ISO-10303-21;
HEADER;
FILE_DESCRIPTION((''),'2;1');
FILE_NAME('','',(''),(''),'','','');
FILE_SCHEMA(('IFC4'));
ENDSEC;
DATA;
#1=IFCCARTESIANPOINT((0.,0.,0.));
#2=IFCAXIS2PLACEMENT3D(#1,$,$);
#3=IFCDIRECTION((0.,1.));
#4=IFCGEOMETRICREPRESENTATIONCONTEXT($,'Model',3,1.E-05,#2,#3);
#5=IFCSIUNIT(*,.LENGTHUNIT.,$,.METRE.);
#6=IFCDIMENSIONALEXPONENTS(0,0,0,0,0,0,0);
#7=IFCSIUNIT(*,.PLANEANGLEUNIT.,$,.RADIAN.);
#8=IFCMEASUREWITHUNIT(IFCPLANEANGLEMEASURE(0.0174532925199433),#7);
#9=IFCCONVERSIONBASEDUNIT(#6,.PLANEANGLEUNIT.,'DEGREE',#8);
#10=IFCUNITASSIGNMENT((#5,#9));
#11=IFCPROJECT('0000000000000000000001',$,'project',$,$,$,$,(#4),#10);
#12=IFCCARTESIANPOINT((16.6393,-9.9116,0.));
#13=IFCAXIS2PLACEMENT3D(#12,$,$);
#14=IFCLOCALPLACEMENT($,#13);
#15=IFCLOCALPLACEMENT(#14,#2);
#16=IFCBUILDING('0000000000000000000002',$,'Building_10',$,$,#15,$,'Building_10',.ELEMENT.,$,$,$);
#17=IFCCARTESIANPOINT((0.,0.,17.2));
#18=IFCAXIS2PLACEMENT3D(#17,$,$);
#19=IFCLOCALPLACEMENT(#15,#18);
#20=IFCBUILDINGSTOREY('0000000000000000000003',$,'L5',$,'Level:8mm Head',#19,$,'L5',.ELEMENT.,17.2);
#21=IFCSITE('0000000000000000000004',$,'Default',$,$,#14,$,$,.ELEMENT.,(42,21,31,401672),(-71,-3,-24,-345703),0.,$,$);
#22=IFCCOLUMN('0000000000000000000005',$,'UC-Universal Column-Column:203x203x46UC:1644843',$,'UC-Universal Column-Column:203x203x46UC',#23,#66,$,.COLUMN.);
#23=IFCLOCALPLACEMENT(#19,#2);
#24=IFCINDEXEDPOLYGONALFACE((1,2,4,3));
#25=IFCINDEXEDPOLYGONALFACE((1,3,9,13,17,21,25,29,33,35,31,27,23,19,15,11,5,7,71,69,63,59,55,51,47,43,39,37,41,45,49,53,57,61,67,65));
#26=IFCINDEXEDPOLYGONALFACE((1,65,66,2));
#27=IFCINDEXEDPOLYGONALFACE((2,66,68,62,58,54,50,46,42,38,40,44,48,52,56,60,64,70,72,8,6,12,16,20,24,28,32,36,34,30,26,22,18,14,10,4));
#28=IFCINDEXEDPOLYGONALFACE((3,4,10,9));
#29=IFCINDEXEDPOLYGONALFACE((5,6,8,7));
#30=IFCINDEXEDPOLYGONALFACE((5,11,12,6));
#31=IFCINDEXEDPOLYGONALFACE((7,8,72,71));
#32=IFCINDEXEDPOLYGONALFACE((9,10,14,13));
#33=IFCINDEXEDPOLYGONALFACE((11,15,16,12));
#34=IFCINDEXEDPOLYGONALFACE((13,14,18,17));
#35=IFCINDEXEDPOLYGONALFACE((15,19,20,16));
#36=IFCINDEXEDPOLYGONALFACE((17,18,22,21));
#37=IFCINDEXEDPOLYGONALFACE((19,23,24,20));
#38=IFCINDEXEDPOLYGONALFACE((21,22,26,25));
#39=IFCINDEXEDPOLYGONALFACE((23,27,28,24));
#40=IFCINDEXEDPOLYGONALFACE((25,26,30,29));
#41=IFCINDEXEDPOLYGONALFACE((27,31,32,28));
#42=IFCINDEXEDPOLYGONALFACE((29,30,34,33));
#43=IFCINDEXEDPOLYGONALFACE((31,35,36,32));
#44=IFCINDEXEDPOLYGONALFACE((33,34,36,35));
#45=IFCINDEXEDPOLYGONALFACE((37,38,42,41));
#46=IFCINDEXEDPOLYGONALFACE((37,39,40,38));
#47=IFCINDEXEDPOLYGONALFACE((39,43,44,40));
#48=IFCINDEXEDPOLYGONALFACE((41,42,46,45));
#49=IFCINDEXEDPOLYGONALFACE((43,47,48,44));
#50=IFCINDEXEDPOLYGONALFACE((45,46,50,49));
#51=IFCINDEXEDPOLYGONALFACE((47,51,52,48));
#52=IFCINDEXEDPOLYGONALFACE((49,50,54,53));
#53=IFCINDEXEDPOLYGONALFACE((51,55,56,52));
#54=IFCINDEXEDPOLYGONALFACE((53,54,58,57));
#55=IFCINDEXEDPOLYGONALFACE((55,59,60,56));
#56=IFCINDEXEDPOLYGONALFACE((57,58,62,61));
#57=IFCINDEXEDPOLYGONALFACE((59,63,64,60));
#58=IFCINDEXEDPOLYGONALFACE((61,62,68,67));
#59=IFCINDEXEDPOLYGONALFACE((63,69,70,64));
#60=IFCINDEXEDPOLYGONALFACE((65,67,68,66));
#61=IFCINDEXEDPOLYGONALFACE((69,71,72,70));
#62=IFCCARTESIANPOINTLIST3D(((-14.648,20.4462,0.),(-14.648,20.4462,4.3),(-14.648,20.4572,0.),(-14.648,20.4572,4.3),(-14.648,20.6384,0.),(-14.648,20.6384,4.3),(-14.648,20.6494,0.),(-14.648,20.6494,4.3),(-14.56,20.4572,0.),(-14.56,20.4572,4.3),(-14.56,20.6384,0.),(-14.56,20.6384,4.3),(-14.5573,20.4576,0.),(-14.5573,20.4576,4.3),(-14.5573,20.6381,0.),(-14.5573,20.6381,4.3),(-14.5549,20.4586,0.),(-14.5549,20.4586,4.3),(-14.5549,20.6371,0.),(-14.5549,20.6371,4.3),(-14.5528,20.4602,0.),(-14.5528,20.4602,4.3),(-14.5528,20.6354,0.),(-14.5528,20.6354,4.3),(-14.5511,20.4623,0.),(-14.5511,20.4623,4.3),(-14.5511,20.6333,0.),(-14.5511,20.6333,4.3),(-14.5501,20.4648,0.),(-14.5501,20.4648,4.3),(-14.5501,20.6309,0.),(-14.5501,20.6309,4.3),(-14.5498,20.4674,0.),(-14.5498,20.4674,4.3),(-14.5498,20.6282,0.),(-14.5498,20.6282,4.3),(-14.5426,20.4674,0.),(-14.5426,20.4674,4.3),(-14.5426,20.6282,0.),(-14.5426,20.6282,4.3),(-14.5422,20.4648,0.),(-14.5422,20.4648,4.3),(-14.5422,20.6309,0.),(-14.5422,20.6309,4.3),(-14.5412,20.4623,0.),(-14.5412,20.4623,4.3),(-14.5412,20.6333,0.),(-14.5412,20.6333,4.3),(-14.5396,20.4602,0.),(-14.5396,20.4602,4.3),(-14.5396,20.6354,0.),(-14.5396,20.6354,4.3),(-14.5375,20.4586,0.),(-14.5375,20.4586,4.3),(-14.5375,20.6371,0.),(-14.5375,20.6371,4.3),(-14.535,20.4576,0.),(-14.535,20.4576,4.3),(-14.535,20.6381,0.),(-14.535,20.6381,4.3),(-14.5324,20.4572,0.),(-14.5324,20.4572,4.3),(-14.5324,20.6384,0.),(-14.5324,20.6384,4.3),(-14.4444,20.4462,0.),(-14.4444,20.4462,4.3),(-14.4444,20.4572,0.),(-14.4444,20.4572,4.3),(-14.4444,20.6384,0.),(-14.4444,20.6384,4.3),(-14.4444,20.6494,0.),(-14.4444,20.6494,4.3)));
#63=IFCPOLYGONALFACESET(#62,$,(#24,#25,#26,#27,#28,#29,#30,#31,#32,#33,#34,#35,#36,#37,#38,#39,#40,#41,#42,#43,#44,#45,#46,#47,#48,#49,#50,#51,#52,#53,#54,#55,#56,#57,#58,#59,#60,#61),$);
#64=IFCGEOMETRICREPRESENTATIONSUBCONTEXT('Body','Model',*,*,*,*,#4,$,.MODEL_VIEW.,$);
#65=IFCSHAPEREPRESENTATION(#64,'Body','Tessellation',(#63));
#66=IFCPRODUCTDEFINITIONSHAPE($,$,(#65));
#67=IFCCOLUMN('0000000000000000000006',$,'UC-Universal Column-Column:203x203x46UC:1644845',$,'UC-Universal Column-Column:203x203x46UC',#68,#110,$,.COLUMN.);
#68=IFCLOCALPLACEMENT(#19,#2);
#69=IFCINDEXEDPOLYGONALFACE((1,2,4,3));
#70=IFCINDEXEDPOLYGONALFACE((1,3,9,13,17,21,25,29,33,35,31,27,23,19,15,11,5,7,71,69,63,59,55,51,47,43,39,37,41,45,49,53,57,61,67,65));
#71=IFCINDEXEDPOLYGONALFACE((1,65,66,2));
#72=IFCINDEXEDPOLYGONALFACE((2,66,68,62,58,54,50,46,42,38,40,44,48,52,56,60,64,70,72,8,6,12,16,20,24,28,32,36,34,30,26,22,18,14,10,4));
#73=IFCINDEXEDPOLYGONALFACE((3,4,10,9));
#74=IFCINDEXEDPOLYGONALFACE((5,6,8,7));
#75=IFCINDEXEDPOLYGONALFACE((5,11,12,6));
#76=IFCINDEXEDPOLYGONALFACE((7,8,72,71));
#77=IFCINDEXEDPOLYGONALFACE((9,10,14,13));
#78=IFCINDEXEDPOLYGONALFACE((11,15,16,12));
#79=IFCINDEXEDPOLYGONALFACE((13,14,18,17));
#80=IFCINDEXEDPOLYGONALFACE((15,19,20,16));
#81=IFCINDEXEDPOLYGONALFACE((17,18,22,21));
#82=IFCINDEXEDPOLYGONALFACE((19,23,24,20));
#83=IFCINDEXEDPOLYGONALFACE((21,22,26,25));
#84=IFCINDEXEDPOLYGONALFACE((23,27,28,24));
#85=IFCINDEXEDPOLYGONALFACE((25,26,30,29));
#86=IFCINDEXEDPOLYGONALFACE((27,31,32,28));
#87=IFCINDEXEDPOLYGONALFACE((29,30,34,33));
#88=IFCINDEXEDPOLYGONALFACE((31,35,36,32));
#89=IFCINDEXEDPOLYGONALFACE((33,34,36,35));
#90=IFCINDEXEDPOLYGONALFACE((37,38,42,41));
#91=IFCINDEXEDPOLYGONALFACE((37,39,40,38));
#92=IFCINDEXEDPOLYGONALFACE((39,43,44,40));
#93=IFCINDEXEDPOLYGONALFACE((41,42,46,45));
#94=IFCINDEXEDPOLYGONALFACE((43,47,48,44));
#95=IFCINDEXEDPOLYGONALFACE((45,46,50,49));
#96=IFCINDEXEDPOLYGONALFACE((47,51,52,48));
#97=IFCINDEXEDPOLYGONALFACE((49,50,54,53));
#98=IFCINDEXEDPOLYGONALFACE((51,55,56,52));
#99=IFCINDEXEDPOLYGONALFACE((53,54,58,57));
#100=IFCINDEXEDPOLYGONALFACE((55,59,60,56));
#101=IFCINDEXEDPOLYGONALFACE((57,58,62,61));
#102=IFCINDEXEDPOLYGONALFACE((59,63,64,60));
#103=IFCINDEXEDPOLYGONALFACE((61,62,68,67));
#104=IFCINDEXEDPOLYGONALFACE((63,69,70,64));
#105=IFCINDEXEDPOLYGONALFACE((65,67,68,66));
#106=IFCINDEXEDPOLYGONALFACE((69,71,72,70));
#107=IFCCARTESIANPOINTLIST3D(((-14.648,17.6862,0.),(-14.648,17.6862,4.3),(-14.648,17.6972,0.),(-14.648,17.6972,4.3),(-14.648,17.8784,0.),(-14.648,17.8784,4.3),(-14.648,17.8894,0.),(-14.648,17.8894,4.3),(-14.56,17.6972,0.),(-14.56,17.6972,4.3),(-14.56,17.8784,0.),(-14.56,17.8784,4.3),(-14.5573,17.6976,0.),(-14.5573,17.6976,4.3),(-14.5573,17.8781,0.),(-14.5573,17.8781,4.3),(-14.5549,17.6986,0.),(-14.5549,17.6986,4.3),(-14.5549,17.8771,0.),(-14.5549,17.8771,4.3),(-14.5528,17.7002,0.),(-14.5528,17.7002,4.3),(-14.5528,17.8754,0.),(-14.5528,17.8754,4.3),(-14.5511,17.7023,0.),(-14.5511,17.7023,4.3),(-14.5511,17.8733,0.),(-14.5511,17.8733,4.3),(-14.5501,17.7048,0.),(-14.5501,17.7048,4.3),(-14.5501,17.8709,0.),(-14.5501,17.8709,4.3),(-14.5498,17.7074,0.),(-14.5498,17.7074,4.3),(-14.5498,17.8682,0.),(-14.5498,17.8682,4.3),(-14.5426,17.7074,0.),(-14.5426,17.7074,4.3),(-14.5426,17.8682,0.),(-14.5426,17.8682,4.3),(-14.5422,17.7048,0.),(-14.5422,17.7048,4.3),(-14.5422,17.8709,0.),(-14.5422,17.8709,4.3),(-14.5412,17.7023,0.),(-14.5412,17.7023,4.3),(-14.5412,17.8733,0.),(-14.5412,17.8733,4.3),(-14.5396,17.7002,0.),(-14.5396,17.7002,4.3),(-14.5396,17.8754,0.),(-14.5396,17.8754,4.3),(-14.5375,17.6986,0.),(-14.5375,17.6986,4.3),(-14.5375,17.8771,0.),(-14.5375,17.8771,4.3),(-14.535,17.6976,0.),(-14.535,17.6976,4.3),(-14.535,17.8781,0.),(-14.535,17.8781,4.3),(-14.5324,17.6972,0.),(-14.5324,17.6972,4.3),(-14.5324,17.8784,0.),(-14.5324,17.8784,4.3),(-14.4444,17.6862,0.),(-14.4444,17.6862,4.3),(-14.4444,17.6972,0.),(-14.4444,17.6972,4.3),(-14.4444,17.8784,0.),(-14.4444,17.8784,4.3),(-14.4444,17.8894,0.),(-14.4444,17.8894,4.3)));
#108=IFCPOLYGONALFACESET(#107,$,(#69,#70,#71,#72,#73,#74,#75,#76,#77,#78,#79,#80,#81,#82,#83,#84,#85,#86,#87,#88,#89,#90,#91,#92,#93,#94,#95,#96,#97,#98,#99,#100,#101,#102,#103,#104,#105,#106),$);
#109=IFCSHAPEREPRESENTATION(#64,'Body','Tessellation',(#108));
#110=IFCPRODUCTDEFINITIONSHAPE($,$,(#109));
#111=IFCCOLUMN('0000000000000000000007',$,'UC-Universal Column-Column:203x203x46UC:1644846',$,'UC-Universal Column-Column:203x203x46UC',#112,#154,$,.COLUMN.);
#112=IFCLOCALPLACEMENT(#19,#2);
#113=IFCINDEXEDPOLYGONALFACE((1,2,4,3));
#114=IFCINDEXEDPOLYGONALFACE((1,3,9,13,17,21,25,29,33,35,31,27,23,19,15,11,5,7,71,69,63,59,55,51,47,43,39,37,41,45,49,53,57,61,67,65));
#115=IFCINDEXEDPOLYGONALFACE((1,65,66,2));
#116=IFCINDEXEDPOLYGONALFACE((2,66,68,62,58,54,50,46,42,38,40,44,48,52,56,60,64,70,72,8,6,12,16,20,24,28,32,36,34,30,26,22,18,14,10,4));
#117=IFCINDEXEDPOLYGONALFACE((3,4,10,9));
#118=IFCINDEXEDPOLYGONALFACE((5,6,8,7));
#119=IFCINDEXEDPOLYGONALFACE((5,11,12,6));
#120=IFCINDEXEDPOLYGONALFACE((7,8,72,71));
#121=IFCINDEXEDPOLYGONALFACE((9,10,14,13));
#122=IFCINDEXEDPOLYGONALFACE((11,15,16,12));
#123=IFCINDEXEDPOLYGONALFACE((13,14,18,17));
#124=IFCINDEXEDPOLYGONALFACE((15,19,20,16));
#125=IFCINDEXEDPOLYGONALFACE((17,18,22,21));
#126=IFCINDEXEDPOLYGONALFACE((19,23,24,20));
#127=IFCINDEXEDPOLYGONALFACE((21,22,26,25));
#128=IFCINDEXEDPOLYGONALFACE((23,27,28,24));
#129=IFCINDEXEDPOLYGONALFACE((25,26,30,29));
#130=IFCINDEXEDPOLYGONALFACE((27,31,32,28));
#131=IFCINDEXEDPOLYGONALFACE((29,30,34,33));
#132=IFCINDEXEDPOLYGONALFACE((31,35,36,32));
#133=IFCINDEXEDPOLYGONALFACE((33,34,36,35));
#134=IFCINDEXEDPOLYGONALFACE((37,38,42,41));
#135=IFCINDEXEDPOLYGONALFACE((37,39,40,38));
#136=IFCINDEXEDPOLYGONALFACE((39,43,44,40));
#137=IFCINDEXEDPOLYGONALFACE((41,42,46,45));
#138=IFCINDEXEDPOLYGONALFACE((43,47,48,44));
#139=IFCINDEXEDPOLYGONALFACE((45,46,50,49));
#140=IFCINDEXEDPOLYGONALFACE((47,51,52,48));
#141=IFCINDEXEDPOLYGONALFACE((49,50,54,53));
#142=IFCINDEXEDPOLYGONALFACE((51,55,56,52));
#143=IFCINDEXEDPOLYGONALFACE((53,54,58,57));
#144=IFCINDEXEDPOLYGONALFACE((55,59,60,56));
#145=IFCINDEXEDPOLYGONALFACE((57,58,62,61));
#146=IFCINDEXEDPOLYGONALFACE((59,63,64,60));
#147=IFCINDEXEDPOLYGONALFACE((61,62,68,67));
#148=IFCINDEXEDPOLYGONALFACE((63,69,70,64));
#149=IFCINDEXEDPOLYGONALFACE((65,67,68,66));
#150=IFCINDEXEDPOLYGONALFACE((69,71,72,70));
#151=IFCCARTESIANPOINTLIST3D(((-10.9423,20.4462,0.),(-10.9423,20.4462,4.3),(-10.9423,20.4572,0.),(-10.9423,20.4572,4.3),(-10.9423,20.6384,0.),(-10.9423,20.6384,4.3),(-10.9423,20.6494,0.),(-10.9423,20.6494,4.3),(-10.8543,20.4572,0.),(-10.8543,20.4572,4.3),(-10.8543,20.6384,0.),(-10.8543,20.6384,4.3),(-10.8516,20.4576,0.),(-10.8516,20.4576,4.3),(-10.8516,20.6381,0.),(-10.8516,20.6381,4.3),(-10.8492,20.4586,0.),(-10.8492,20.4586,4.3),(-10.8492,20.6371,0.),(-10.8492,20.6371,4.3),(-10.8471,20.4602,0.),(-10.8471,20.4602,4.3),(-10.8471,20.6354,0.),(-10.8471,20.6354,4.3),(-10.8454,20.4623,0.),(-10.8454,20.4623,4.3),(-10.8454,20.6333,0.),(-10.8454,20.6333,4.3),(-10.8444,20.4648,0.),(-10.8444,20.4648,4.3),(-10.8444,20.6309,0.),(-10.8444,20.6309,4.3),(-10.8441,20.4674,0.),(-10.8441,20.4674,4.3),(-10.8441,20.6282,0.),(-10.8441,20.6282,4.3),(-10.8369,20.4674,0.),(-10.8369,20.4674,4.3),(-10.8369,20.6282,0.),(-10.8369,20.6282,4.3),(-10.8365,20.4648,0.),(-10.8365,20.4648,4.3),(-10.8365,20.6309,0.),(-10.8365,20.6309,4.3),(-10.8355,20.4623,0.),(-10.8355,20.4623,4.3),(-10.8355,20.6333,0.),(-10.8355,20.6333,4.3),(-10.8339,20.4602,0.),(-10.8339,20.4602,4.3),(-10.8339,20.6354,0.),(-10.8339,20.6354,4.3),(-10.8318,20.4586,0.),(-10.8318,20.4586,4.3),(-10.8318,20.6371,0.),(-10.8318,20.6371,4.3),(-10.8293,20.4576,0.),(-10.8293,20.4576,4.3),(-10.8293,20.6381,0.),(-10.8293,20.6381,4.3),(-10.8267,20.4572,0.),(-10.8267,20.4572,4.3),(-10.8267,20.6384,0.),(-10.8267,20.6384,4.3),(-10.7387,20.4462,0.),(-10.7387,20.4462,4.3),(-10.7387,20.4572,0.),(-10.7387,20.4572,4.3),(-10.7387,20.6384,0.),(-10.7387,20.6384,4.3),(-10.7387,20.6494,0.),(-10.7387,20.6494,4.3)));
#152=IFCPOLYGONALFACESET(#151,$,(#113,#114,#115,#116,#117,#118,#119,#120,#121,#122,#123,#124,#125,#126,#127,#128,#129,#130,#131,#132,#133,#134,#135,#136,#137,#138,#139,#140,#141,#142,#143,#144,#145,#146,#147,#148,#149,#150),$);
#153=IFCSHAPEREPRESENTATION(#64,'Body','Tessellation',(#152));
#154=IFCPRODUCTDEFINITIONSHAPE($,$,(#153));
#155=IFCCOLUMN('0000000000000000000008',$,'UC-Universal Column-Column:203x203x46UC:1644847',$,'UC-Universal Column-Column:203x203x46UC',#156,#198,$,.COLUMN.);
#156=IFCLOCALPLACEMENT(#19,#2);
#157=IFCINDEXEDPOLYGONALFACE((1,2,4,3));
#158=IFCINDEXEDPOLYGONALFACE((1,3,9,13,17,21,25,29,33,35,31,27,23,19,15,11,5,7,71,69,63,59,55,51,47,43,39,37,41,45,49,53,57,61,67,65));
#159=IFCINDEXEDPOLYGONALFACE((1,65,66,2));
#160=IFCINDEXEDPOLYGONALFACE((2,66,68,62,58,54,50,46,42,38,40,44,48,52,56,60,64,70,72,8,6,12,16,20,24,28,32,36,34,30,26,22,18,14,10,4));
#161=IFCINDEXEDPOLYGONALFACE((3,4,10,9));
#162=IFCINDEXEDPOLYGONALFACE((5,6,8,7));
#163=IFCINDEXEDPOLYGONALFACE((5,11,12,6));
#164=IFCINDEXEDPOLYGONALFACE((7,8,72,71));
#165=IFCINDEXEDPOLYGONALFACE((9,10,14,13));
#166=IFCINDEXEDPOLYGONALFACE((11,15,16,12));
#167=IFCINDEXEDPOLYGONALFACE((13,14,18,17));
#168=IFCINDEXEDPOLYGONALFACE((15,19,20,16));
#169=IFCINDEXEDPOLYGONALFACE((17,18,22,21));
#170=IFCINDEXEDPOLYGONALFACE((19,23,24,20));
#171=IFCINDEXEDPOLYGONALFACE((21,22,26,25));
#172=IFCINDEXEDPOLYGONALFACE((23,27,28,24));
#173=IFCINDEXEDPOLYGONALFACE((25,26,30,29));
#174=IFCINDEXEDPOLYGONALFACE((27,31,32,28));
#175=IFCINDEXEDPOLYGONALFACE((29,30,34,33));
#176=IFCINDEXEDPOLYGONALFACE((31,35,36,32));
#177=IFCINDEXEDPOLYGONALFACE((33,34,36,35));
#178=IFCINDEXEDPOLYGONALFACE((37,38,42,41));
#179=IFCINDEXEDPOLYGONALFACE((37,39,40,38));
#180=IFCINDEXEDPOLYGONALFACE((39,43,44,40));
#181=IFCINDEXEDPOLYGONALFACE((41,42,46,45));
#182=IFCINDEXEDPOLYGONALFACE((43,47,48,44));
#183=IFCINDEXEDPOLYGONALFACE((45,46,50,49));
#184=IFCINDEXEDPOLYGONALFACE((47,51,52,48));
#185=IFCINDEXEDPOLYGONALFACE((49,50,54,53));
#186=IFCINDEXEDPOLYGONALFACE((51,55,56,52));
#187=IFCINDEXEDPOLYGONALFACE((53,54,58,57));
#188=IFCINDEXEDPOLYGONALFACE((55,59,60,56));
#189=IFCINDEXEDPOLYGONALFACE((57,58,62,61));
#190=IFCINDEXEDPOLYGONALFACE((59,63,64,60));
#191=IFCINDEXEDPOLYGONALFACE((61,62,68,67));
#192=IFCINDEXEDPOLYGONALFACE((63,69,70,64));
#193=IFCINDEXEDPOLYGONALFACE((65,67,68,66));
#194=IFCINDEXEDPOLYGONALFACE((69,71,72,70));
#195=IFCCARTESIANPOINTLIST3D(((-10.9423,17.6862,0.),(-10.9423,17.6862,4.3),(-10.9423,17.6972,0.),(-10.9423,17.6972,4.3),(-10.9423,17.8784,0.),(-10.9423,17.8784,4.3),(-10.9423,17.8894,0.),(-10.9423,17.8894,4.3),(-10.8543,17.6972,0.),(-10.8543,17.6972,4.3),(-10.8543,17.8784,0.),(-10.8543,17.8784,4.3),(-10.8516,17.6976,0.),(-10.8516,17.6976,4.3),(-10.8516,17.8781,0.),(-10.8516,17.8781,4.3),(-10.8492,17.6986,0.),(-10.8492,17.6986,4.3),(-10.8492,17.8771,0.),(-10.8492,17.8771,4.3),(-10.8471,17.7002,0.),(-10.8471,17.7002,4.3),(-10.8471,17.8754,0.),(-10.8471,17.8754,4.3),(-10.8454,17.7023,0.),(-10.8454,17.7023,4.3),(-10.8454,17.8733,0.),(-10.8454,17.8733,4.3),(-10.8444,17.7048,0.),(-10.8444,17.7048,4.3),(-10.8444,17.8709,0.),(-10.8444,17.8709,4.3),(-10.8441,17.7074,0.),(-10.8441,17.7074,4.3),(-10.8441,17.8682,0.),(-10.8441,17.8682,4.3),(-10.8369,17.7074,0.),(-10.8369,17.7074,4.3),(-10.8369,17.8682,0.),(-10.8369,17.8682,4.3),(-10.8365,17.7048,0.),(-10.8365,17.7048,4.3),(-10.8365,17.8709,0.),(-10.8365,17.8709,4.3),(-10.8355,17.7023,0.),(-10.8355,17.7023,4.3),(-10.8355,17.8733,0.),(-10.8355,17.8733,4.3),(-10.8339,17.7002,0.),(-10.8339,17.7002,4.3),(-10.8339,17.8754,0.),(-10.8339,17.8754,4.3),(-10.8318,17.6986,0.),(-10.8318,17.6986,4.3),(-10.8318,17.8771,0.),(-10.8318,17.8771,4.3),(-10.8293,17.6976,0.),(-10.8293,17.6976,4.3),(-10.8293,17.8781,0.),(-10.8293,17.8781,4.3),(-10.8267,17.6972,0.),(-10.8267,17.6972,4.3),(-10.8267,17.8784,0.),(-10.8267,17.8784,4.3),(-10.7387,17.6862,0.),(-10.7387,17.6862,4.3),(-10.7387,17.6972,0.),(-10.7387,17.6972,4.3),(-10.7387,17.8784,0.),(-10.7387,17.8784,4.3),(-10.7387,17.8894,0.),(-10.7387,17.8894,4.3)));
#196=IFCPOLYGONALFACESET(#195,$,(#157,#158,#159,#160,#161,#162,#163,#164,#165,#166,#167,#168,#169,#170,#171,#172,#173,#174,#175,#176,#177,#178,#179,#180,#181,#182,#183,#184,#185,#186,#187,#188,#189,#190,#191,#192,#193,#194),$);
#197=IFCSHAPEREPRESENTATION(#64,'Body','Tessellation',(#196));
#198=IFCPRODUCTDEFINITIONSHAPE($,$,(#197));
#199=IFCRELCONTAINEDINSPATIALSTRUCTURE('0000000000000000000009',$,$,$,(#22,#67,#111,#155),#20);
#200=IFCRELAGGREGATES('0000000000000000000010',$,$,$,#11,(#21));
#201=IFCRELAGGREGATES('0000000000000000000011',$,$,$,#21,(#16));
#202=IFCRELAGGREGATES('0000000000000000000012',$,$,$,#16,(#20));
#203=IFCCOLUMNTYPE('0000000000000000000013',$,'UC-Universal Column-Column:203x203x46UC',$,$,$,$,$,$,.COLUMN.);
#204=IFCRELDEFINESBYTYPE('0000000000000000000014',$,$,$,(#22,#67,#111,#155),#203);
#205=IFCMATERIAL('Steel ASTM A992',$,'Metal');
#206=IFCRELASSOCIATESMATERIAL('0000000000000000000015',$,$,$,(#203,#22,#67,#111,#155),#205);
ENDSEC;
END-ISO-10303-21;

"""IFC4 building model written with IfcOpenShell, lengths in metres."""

from ifc_helpers import new_model, entity, si_unit, converted_unit, direction, frame, origin, place, context, subcontext, project, spatial, line, arc, indexed_curve, outline, extrude, source, transform, mapped, material, type_object, type_shapes, element, save


model = new_model("IFC4")

# Units and contexts
model_context = context("Model", 3, precision=1e-05, world=origin(), true_north=direction((0.0, 1.0)))
body_context = subcontext(model_context, "Body", "Model", "MODEL_VIEW")
ifc_project = project(units=[si_unit("LENGTHUNIT", "METRE"), converted_unit("PLANEANGLEUNIT", "DEGREE", entity("IfcPlaneAngleMeasure", 0.0174532925199433), si_unit("PLANEANGLEUNIT", "RADIAN"), dimensions=[0, 0, 0, 0, 0, 0, 0])], contexts=[model_context])

# Site, building, storey
site_placement = place(None, frame((16.6393, -9.9116, 0.0)))
site = spatial("IfcSite", under=ifc_project, at=site_placement, Name="Default", CompositionType="ELEMENT", RefLatitude=(42, 21, 31, 401672), RefLongitude=(-71, -3, -24, -345703), RefElevation=0.0)
building_placement = place(site_placement, origin())
building = spatial("IfcBuilding", under=site, at=building_placement, Name="Building_10", LongName="Building_10", CompositionType="ELEMENT")
storey_placement = place(building_placement, frame((0.0, 0.0, 17.2)))
storey = spatial("IfcBuildingStorey", under=building, at=storey_placement, Name="L5", ObjectType="Level:8mm Head", LongName="L5", CompositionType="ELEMENT", Elevation=17.2)

# Columns
ifc_material = material(Name="Steel ASTM A992", Category="Metal")
column_type = type_object("IfcColumnType", Name="UC-Universal Column-Column:203x203x46UC", PredefinedType="COLUMN", material=ifc_material)
shared_shape_1 = source(origin(), body_context, "Body", "SweptSolid", [
    extrude(outline(indexed_curve([(-0.1018, -0.1016), (0.1018, -0.1016), (0.1018, -0.0906), (0.0138, -0.0906), (0.0066, -0.0876), (0.0036, -0.0804), (0.0036, 0.0804), (0.0066, 0.0876), (0.0138, 0.0906), (0.1018, 0.0906), (0.1018, 0.1016), (-0.1018, 0.1016), (-0.1018, 0.0906), (-0.0138, 0.0906), (-0.0066, 0.0876), (-0.0036, 0.0804), (-0.0036, -0.0804), (-0.0066, -0.0876), (-0.0138, -0.0906), (-0.1018, -0.0906)], segments=[line(1, 2, 3, 4), arc(4, 5, 6), line(6, 7), arc(7, 8, 9), line(9, 10, 11, 12, 13, 14), arc(14, 15, 16), line(16, 17), arc(17, 18, 19), line(19, 20, 1)], self_intersect=False)), frame((0.0, 0.0, 17.2), z_axis=(0.0, 0.0, 1.0), x_axis=(-1.0, 0.0, 0.0)), (0.0, 0.0, 1.0), 4.3),
])
type_shapes(column_type, [shared_shape_1])
for number, where, name in (
    (1, (-14.5462, 20.5478, -17.2), "UC-Universal Column-Column:203x203x46UC:1644843"),
    (2, (-14.5462, 17.7878, -17.2), "UC-Universal Column-Column:203x203x46UC:1644845"),
    (3, (-10.8405, 20.5478, -17.2), "UC-Universal Column-Column:203x203x46UC:1644846"),
    (4, (-10.8405, 17.7878, -17.2), "UC-Universal Column-Column:203x203x46UC:1644847"),
):
    element("IfcColumn", number, at=place(storey_placement, frame(where)), inside=storey, type_object=column_type, material=ifc_material, Name=name, ObjectType="UC-Universal Column-Column:203x203x46UC", PredefinedType="COLUMN", context=body_context, shape_type="MappedRepresentation", body=[
        mapped(shared_shape_1, transform((0.0, 0.0, 0.0), scale=1.0)),
    ])

save(model, "model.ifc")
